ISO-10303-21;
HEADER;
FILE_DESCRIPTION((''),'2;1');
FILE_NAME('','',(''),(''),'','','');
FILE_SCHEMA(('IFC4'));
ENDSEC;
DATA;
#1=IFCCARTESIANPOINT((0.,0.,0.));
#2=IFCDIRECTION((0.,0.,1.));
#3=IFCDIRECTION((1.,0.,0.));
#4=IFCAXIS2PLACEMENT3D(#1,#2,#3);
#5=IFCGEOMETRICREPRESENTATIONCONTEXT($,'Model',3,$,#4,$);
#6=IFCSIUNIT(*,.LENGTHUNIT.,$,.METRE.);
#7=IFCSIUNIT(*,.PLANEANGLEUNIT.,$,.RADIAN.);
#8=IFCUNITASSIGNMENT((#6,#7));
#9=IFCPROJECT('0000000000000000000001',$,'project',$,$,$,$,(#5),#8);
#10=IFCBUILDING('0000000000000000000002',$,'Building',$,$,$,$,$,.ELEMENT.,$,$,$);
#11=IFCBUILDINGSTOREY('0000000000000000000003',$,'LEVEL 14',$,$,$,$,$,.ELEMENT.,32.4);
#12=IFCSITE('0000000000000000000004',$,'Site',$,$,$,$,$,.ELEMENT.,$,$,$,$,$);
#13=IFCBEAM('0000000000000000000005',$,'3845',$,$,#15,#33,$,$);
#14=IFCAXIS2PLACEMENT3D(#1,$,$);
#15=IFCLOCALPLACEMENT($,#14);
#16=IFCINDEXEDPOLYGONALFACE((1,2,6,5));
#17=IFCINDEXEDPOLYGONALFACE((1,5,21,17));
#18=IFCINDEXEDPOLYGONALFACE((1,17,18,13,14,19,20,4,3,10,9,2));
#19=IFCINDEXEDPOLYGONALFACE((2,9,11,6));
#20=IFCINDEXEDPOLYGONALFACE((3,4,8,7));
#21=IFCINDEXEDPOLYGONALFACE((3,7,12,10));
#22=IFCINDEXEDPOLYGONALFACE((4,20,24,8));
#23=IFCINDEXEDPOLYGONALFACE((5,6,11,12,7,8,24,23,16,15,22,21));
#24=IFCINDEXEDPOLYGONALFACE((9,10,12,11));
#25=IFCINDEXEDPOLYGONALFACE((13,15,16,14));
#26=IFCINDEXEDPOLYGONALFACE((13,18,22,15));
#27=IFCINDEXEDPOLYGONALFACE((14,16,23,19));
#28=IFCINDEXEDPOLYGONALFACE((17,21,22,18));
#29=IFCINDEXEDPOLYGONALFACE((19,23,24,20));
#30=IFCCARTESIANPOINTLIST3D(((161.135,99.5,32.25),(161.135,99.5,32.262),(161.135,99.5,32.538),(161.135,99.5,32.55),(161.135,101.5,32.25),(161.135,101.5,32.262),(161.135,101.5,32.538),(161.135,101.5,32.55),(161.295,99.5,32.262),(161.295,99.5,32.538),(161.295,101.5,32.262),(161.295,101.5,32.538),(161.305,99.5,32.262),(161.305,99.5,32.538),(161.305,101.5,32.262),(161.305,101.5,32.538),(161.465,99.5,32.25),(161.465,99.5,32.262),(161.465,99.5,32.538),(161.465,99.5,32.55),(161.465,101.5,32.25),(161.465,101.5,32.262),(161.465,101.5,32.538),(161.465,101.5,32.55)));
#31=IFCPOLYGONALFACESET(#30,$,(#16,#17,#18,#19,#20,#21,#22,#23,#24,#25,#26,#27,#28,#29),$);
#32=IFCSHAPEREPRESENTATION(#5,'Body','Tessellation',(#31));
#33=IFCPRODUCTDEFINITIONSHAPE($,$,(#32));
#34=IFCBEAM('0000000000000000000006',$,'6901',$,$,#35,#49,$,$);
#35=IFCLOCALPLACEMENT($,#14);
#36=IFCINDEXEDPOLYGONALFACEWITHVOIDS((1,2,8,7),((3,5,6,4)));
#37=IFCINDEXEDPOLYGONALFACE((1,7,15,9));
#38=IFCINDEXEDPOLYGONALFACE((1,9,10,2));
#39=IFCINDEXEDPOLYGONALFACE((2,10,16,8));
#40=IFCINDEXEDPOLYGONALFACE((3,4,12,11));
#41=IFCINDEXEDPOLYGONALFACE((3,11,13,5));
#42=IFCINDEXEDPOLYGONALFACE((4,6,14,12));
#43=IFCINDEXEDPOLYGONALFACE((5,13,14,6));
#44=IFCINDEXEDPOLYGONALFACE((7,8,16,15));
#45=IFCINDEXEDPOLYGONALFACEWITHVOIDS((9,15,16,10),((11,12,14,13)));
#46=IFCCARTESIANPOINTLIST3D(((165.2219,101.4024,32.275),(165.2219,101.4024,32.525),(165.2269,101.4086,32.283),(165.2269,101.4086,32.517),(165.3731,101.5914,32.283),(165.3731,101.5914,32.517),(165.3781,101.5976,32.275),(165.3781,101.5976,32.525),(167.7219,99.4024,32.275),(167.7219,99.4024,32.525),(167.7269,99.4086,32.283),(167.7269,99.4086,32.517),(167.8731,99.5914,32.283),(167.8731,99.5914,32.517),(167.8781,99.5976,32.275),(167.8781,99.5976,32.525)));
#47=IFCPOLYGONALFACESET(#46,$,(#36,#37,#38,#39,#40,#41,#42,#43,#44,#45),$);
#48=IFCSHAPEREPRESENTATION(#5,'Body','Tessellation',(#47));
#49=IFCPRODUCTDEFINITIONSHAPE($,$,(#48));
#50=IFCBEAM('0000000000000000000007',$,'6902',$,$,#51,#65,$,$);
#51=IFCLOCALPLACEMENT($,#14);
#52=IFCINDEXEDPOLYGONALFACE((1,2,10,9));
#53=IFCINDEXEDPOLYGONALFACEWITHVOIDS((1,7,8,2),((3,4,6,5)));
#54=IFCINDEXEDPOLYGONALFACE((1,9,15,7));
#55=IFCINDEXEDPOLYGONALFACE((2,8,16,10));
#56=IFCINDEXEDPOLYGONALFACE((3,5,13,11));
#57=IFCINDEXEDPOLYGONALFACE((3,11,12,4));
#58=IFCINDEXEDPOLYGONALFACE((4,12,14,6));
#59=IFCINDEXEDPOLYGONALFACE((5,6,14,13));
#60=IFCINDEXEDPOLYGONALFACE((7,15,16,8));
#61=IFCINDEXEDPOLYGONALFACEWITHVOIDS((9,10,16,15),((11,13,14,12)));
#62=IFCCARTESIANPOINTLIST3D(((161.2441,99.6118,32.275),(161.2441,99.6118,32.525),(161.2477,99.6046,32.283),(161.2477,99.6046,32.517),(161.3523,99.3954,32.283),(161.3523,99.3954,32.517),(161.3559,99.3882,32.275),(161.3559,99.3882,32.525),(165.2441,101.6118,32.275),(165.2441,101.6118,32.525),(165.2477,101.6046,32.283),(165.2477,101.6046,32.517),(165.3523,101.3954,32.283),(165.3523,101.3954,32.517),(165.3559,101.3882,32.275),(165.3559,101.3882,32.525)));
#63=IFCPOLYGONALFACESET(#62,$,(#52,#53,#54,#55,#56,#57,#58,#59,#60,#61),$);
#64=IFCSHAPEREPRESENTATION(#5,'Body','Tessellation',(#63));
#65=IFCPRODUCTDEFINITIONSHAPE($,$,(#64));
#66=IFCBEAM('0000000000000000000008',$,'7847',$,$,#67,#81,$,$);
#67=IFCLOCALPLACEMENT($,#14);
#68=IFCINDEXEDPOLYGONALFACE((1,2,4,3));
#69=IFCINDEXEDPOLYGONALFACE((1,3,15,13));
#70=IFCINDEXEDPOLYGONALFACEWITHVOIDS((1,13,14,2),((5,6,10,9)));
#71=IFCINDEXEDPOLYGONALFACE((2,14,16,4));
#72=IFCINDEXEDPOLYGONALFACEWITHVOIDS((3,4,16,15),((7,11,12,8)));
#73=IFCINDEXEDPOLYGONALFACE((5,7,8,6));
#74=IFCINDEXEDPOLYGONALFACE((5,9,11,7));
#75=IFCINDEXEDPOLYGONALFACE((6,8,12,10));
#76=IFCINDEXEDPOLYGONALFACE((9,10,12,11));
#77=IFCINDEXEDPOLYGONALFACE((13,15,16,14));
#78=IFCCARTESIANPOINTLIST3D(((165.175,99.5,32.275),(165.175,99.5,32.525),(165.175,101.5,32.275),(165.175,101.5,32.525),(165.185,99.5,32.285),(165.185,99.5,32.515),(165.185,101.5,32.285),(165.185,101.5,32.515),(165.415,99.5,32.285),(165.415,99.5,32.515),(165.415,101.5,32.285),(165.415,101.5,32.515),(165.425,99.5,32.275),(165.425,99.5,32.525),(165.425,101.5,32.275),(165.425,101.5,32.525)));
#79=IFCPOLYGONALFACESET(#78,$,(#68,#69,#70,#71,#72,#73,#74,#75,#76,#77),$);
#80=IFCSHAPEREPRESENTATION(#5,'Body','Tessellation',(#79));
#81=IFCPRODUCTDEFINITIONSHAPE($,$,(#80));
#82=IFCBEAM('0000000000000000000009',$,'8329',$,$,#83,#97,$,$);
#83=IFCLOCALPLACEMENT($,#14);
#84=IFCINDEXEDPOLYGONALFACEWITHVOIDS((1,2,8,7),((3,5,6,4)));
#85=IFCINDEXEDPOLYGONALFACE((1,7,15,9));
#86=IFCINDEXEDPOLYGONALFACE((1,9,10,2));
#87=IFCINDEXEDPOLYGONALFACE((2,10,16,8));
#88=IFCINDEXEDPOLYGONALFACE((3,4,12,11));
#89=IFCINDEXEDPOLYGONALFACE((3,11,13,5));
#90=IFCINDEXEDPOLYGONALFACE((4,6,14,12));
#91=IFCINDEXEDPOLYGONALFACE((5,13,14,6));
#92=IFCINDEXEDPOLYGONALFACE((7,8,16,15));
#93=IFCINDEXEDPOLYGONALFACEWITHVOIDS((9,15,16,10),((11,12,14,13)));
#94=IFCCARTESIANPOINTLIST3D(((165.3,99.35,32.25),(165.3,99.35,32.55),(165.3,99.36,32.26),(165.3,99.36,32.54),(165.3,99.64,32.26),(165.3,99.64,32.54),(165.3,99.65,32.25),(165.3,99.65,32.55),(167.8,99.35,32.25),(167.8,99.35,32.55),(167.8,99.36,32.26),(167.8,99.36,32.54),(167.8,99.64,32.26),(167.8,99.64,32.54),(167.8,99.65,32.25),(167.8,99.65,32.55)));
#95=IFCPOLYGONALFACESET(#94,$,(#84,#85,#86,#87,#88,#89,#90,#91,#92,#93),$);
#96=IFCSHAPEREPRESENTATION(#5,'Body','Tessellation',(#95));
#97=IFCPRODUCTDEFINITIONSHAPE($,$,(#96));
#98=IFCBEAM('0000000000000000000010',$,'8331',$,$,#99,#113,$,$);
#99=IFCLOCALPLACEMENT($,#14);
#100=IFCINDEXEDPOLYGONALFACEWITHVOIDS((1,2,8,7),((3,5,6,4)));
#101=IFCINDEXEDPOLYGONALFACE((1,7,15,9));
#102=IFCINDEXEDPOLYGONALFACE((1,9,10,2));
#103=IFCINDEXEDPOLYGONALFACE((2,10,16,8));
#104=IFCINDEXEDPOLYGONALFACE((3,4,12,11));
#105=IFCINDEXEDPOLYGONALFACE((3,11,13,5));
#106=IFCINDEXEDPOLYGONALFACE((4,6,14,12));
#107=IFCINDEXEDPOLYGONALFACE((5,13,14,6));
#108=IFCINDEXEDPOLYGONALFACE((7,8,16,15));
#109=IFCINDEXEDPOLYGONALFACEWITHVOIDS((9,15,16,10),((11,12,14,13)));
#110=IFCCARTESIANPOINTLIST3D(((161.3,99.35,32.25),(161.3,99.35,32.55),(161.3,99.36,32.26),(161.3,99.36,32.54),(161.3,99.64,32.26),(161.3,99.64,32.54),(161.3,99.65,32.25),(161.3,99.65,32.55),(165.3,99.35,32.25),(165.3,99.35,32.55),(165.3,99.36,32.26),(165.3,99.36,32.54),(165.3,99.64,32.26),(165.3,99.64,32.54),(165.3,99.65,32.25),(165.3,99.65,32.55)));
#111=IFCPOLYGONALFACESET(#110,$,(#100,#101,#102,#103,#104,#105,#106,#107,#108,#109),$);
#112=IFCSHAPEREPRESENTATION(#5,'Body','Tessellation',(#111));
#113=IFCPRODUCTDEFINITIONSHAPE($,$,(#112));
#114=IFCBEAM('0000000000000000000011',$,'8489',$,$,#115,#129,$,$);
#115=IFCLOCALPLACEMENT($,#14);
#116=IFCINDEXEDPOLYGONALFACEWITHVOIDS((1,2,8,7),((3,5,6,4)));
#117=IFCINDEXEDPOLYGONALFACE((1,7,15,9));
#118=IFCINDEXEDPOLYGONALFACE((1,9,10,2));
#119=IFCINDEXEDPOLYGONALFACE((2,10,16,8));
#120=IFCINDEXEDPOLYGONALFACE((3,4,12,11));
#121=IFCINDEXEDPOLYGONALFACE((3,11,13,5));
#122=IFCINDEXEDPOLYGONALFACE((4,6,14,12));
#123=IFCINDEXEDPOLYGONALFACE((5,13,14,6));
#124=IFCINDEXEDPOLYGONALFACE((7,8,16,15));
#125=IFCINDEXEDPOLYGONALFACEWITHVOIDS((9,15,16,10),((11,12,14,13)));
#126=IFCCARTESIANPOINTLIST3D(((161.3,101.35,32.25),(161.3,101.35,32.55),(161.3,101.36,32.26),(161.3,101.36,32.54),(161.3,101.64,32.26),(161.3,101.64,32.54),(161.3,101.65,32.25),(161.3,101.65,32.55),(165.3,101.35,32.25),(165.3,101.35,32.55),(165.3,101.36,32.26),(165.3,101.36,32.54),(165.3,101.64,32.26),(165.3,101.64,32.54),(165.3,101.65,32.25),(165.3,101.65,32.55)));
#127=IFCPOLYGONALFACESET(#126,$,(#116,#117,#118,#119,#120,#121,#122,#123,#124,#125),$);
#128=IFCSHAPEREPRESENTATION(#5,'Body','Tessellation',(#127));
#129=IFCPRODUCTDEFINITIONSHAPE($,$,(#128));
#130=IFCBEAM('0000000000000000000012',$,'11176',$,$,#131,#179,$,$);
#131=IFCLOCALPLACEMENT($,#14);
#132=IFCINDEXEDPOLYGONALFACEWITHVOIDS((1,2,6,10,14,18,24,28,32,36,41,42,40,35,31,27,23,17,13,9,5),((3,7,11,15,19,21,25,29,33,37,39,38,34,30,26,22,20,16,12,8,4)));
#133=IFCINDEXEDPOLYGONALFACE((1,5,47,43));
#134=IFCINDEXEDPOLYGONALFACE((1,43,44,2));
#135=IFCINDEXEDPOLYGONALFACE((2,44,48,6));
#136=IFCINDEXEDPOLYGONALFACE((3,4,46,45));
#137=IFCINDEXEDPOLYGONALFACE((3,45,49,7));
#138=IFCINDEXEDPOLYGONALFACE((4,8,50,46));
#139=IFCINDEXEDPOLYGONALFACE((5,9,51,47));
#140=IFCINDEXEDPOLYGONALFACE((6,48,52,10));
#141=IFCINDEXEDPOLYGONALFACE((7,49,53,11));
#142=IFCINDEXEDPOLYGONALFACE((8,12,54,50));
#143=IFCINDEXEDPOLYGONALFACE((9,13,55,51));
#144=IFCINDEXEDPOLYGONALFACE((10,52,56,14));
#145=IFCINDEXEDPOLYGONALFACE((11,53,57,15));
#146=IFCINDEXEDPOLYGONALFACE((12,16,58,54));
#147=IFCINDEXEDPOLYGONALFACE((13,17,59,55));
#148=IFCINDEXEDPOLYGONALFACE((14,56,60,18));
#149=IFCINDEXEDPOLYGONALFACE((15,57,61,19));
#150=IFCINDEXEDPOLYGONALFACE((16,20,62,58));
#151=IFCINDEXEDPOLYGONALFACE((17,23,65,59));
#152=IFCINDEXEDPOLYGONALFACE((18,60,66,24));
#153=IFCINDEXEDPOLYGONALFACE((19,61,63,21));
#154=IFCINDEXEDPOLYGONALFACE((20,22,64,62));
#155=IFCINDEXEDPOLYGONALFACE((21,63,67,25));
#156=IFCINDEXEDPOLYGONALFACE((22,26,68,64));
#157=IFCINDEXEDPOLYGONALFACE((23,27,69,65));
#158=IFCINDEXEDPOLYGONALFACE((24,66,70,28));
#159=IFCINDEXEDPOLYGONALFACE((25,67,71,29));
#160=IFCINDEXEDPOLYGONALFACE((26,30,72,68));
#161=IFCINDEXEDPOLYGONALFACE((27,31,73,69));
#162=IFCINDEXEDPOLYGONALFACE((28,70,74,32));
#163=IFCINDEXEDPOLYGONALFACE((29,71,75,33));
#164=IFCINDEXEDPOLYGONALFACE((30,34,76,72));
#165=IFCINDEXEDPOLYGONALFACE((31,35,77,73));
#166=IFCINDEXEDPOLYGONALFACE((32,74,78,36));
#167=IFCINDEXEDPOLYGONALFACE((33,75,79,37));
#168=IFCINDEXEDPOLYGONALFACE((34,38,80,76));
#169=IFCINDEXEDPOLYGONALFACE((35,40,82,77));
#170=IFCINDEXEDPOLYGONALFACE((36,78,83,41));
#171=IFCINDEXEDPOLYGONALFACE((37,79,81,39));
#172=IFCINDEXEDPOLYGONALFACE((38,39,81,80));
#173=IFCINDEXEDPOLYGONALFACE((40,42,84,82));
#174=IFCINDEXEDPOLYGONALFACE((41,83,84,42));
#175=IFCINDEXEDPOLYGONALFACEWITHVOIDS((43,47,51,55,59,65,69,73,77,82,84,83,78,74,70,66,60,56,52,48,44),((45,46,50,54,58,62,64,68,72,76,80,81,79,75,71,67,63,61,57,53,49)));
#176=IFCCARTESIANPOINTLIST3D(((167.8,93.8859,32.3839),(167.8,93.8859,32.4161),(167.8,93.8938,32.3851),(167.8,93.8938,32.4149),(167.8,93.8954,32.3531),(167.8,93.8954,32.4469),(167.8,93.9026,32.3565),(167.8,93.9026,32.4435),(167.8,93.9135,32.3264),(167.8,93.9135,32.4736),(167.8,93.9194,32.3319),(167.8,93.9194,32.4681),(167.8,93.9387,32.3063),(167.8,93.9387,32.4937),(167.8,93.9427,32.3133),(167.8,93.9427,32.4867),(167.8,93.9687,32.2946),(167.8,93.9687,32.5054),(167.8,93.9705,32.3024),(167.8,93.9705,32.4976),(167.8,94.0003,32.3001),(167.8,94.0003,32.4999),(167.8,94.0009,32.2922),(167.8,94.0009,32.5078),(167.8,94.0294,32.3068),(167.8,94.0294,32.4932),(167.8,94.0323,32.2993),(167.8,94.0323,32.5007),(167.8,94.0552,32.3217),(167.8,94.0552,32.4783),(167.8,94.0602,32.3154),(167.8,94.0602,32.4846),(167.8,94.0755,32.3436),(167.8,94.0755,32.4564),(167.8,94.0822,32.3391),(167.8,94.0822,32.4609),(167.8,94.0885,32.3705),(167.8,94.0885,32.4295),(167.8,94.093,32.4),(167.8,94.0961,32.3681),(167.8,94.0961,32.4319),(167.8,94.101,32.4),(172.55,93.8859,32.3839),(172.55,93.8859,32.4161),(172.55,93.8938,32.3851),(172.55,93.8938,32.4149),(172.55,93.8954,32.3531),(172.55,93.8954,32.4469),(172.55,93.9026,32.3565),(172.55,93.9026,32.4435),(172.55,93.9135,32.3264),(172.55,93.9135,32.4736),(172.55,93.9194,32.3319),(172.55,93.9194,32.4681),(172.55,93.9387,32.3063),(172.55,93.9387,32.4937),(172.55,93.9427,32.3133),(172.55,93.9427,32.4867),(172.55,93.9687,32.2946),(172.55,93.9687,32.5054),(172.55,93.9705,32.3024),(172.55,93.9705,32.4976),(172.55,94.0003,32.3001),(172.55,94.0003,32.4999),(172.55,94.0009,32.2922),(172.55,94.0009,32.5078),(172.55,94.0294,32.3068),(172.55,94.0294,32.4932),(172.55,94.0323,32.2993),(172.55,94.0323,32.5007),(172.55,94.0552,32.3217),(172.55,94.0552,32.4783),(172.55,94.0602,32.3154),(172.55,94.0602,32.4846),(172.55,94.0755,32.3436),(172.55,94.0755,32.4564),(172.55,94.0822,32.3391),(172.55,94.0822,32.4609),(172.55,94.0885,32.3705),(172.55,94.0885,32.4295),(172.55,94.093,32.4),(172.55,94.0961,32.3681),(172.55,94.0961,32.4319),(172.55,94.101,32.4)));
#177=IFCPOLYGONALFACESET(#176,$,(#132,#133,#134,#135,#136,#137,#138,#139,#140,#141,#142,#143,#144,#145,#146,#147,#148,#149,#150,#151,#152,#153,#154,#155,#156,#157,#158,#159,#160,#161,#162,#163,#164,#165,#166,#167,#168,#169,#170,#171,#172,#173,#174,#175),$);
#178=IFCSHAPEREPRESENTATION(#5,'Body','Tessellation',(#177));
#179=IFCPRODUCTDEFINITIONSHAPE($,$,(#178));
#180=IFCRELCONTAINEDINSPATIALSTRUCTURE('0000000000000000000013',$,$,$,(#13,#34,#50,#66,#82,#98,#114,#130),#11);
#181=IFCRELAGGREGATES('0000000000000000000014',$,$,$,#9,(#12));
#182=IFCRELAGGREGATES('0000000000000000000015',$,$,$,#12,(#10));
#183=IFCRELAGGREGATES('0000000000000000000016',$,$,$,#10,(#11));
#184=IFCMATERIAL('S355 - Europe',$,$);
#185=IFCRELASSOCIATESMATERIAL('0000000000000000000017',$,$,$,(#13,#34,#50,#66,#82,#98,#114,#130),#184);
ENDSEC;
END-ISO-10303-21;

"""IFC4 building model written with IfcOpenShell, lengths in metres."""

from ifc_helpers import new_model, si_unit, frame, origin_with_axes, origin_2d_with_axis, place, context, project, spatial, hollow_rectangle, hollow_circle, i_section, extrude, material, material_profile, profile_set, profile_usage, element, save


model = new_model("IFC4")

# Units and contexts
model_context = context("Model", 3, world=origin_with_axes())
ifc_project = project(units=[si_unit("LENGTHUNIT", "METRE"), si_unit("PLANEANGLEUNIT", "RADIAN")], contexts=[model_context])

# Site, building, storey
site = spatial("IfcSite", under=ifc_project, Name="Site", CompositionType="ELEMENT")
building = spatial("IfcBuilding", under=site, Name="Building", CompositionType="ELEMENT")
storey = spatial("IfcBuildingStorey", under=building, Name="LEVEL 14", CompositionType="ELEMENT", Elevation=32.4)

# Shared definitions
ifc_material = material(Name="S355 - Europe")

# Beams
ifc_material_profile_1 = material_profile(ifc_material, i_section(OverallWidth=0.33, OverallDepth=0.3, WebThickness=0.01, FlangeThickness=0.012, at=origin_2d_with_axis()))
ifc_profile_set_1 = profile_set([ifc_material_profile_1])
ifc_profile_usage_1 = profile_usage(ifc_profile_set_1, cardinal=10)
beam_1_placement = place(None, frame((161.3, 101.5, 32.4), z_axis=(0.0, -1.0, 0.0), x_axis=(1.0, 0.0, 0.0)))
element("IfcBeam", 1, at=beam_1_placement, inside=storey, material=ifc_profile_usage_1, Name="3845", context=model_context, shape_type="SweptSolid", body=[
    extrude(i_section(OverallWidth=0.33, OverallDepth=0.3, WebThickness=0.01, FlangeThickness=0.012, at=origin_2d_with_axis()), origin_with_axes(), (0.0, 0.0, 1.0), 2.0),
])
ifc_material_profile_2 = material_profile(ifc_material, hollow_rectangle(XDim=0.25, YDim=0.25, WallThickness=0.008, at=origin_2d_with_axis()))
ifc_profile_set_2 = profile_set([ifc_material_profile_2])
ifc_profile_usage_2 = profile_usage(ifc_profile_set_2, cardinal=10)
beam_2_placement = place(None, frame((167.8, 99.5, 32.4), z_axis=(-0.780869, 0.624695, 0.0), x_axis=(-0.624695, -0.780869, 0.0)))
element("IfcBeam", 2, at=beam_2_placement, inside=storey, material=ifc_profile_usage_2, Name="6901", context=model_context, shape_type="SweptSolid", body=[
    extrude(hollow_rectangle(XDim=0.25, YDim=0.25, WallThickness=0.008, at=origin_2d_with_axis()), origin_with_axes(), (0.0, 0.0, 1.0), 3.2016),
])
ifc_material_profile_3 = material_profile(ifc_material, hollow_rectangle(XDim=0.25, YDim=0.25, WallThickness=0.008, at=origin_2d_with_axis()))
ifc_profile_set_3 = profile_set([ifc_material_profile_3])
ifc_profile_usage_3 = profile_usage(ifc_profile_set_3, cardinal=10)
beam_3_placement = place(None, frame((165.3, 101.5, 32.4), z_axis=(-0.894427, -0.447214, 0.0), x_axis=(0.447214, -0.894427, 0.0)))
element("IfcBeam", 3, at=beam_3_placement, inside=storey, material=ifc_profile_usage_3, Name="6902", context=model_context, shape_type="SweptSolid", body=[
    extrude(hollow_rectangle(XDim=0.25, YDim=0.25, WallThickness=0.008, at=origin_2d_with_axis()), origin_with_axes(), (0.0, 0.0, 1.0), 4.4721),
])
ifc_material_profile_4 = material_profile(ifc_material, hollow_rectangle(XDim=0.25, YDim=0.25, WallThickness=0.01, at=origin_2d_with_axis()))
ifc_profile_set_4 = profile_set([ifc_material_profile_4])
ifc_profile_usage_4 = profile_usage(ifc_profile_set_4, cardinal=10)
beam_4_placement = place(None, frame((165.3, 101.5, 32.4), z_axis=(0.0, -1.0, 0.0), x_axis=(1.0, 0.0, 0.0)))
element("IfcBeam", 4, at=beam_4_placement, inside=storey, material=ifc_profile_usage_4, Name="7847", context=model_context, shape_type="SweptSolid", body=[
    extrude(hollow_rectangle(XDim=0.25, YDim=0.25, WallThickness=0.01, at=origin_2d_with_axis()), origin_with_axes(), (0.0, 0.0, 1.0), 2.0),
])
ifc_material_profile_5 = material_profile(ifc_material, hollow_rectangle(XDim=0.3, YDim=0.3, WallThickness=0.01, at=origin_2d_with_axis()))
ifc_profile_set_5 = profile_set([ifc_material_profile_5])
ifc_profile_usage_5 = profile_usage(ifc_profile_set_5, cardinal=10)
beam_5_placement = place(None, frame((167.8, 99.5, 32.4), z_axis=(-1.0, 0.0, 0.0), x_axis=(0.0, -1.0, 0.0)))
element("IfcBeam", 5, at=beam_5_placement, inside=storey, material=ifc_profile_usage_5, Name="8329", context=model_context, shape_type="SweptSolid", body=[
    extrude(hollow_rectangle(XDim=0.3, YDim=0.3, WallThickness=0.01, at=origin_2d_with_axis()), origin_with_axes(), (0.0, 0.0, 1.0), 2.5),
])
ifc_material_profile_6 = material_profile(ifc_material, hollow_rectangle(XDim=0.3, YDim=0.3, WallThickness=0.01, at=origin_2d_with_axis()))
ifc_profile_set_6 = profile_set([ifc_material_profile_6])
ifc_profile_usage_6 = profile_usage(ifc_profile_set_6, cardinal=10)
beam_6_placement = place(None, frame((165.3, 99.5, 32.4), z_axis=(-1.0, 0.0, 0.0), x_axis=(0.0, -1.0, 0.0)))
element("IfcBeam", 6, at=beam_6_placement, inside=storey, material=ifc_profile_usage_6, Name="8331", context=model_context, shape_type="SweptSolid", body=[
    extrude(hollow_rectangle(XDim=0.3, YDim=0.3, WallThickness=0.01, at=origin_2d_with_axis()), origin_with_axes(), (0.0, 0.0, 1.0), 4.0),
])
ifc_material_profile_7 = material_profile(ifc_material, hollow_rectangle(XDim=0.3, YDim=0.3, WallThickness=0.01, at=origin_2d_with_axis()))
ifc_profile_set_7 = profile_set([ifc_material_profile_7])
ifc_profile_usage_7 = profile_usage(ifc_profile_set_7, cardinal=10)
beam_7_placement = place(None, frame((165.3, 101.5, 32.4), z_axis=(-1.0, 0.0, 0.0), x_axis=(0.0, -1.0, 0.0)))
element("IfcBeam", 7, at=beam_7_placement, inside=storey, material=ifc_profile_usage_7, Name="8489", context=model_context, shape_type="SweptSolid", body=[
    extrude(hollow_rectangle(XDim=0.3, YDim=0.3, WallThickness=0.01, at=origin_2d_with_axis()), origin_with_axes(), (0.0, 0.0, 1.0), 4.0),
])
ifc_material_profile_8 = material_profile(ifc_material, hollow_circle(Radius=0.1081, WallThickness=0.008, at=origin_2d_with_axis()))
ifc_profile_set_8 = profile_set([ifc_material_profile_8])
ifc_profile_usage_8 = profile_usage(ifc_profile_set_8, cardinal=10)
beam_8_placement = place(None, frame((167.8, 93.9928, 32.4), z_axis=(1.0, 0.0, 0.0), x_axis=(0.0, 1.0, 0.0)))
element("IfcBeam", 8, at=beam_8_placement, inside=storey, material=ifc_profile_usage_8, Name="11176", context=model_context, shape_type="SweptSolid", body=[
    extrude(hollow_circle(Radius=0.1081, WallThickness=0.008, at=origin_2d_with_axis()), origin_with_axes(), (0.0, 0.0, 1.0), 4.75),
])

save(model, "model.ifc")
